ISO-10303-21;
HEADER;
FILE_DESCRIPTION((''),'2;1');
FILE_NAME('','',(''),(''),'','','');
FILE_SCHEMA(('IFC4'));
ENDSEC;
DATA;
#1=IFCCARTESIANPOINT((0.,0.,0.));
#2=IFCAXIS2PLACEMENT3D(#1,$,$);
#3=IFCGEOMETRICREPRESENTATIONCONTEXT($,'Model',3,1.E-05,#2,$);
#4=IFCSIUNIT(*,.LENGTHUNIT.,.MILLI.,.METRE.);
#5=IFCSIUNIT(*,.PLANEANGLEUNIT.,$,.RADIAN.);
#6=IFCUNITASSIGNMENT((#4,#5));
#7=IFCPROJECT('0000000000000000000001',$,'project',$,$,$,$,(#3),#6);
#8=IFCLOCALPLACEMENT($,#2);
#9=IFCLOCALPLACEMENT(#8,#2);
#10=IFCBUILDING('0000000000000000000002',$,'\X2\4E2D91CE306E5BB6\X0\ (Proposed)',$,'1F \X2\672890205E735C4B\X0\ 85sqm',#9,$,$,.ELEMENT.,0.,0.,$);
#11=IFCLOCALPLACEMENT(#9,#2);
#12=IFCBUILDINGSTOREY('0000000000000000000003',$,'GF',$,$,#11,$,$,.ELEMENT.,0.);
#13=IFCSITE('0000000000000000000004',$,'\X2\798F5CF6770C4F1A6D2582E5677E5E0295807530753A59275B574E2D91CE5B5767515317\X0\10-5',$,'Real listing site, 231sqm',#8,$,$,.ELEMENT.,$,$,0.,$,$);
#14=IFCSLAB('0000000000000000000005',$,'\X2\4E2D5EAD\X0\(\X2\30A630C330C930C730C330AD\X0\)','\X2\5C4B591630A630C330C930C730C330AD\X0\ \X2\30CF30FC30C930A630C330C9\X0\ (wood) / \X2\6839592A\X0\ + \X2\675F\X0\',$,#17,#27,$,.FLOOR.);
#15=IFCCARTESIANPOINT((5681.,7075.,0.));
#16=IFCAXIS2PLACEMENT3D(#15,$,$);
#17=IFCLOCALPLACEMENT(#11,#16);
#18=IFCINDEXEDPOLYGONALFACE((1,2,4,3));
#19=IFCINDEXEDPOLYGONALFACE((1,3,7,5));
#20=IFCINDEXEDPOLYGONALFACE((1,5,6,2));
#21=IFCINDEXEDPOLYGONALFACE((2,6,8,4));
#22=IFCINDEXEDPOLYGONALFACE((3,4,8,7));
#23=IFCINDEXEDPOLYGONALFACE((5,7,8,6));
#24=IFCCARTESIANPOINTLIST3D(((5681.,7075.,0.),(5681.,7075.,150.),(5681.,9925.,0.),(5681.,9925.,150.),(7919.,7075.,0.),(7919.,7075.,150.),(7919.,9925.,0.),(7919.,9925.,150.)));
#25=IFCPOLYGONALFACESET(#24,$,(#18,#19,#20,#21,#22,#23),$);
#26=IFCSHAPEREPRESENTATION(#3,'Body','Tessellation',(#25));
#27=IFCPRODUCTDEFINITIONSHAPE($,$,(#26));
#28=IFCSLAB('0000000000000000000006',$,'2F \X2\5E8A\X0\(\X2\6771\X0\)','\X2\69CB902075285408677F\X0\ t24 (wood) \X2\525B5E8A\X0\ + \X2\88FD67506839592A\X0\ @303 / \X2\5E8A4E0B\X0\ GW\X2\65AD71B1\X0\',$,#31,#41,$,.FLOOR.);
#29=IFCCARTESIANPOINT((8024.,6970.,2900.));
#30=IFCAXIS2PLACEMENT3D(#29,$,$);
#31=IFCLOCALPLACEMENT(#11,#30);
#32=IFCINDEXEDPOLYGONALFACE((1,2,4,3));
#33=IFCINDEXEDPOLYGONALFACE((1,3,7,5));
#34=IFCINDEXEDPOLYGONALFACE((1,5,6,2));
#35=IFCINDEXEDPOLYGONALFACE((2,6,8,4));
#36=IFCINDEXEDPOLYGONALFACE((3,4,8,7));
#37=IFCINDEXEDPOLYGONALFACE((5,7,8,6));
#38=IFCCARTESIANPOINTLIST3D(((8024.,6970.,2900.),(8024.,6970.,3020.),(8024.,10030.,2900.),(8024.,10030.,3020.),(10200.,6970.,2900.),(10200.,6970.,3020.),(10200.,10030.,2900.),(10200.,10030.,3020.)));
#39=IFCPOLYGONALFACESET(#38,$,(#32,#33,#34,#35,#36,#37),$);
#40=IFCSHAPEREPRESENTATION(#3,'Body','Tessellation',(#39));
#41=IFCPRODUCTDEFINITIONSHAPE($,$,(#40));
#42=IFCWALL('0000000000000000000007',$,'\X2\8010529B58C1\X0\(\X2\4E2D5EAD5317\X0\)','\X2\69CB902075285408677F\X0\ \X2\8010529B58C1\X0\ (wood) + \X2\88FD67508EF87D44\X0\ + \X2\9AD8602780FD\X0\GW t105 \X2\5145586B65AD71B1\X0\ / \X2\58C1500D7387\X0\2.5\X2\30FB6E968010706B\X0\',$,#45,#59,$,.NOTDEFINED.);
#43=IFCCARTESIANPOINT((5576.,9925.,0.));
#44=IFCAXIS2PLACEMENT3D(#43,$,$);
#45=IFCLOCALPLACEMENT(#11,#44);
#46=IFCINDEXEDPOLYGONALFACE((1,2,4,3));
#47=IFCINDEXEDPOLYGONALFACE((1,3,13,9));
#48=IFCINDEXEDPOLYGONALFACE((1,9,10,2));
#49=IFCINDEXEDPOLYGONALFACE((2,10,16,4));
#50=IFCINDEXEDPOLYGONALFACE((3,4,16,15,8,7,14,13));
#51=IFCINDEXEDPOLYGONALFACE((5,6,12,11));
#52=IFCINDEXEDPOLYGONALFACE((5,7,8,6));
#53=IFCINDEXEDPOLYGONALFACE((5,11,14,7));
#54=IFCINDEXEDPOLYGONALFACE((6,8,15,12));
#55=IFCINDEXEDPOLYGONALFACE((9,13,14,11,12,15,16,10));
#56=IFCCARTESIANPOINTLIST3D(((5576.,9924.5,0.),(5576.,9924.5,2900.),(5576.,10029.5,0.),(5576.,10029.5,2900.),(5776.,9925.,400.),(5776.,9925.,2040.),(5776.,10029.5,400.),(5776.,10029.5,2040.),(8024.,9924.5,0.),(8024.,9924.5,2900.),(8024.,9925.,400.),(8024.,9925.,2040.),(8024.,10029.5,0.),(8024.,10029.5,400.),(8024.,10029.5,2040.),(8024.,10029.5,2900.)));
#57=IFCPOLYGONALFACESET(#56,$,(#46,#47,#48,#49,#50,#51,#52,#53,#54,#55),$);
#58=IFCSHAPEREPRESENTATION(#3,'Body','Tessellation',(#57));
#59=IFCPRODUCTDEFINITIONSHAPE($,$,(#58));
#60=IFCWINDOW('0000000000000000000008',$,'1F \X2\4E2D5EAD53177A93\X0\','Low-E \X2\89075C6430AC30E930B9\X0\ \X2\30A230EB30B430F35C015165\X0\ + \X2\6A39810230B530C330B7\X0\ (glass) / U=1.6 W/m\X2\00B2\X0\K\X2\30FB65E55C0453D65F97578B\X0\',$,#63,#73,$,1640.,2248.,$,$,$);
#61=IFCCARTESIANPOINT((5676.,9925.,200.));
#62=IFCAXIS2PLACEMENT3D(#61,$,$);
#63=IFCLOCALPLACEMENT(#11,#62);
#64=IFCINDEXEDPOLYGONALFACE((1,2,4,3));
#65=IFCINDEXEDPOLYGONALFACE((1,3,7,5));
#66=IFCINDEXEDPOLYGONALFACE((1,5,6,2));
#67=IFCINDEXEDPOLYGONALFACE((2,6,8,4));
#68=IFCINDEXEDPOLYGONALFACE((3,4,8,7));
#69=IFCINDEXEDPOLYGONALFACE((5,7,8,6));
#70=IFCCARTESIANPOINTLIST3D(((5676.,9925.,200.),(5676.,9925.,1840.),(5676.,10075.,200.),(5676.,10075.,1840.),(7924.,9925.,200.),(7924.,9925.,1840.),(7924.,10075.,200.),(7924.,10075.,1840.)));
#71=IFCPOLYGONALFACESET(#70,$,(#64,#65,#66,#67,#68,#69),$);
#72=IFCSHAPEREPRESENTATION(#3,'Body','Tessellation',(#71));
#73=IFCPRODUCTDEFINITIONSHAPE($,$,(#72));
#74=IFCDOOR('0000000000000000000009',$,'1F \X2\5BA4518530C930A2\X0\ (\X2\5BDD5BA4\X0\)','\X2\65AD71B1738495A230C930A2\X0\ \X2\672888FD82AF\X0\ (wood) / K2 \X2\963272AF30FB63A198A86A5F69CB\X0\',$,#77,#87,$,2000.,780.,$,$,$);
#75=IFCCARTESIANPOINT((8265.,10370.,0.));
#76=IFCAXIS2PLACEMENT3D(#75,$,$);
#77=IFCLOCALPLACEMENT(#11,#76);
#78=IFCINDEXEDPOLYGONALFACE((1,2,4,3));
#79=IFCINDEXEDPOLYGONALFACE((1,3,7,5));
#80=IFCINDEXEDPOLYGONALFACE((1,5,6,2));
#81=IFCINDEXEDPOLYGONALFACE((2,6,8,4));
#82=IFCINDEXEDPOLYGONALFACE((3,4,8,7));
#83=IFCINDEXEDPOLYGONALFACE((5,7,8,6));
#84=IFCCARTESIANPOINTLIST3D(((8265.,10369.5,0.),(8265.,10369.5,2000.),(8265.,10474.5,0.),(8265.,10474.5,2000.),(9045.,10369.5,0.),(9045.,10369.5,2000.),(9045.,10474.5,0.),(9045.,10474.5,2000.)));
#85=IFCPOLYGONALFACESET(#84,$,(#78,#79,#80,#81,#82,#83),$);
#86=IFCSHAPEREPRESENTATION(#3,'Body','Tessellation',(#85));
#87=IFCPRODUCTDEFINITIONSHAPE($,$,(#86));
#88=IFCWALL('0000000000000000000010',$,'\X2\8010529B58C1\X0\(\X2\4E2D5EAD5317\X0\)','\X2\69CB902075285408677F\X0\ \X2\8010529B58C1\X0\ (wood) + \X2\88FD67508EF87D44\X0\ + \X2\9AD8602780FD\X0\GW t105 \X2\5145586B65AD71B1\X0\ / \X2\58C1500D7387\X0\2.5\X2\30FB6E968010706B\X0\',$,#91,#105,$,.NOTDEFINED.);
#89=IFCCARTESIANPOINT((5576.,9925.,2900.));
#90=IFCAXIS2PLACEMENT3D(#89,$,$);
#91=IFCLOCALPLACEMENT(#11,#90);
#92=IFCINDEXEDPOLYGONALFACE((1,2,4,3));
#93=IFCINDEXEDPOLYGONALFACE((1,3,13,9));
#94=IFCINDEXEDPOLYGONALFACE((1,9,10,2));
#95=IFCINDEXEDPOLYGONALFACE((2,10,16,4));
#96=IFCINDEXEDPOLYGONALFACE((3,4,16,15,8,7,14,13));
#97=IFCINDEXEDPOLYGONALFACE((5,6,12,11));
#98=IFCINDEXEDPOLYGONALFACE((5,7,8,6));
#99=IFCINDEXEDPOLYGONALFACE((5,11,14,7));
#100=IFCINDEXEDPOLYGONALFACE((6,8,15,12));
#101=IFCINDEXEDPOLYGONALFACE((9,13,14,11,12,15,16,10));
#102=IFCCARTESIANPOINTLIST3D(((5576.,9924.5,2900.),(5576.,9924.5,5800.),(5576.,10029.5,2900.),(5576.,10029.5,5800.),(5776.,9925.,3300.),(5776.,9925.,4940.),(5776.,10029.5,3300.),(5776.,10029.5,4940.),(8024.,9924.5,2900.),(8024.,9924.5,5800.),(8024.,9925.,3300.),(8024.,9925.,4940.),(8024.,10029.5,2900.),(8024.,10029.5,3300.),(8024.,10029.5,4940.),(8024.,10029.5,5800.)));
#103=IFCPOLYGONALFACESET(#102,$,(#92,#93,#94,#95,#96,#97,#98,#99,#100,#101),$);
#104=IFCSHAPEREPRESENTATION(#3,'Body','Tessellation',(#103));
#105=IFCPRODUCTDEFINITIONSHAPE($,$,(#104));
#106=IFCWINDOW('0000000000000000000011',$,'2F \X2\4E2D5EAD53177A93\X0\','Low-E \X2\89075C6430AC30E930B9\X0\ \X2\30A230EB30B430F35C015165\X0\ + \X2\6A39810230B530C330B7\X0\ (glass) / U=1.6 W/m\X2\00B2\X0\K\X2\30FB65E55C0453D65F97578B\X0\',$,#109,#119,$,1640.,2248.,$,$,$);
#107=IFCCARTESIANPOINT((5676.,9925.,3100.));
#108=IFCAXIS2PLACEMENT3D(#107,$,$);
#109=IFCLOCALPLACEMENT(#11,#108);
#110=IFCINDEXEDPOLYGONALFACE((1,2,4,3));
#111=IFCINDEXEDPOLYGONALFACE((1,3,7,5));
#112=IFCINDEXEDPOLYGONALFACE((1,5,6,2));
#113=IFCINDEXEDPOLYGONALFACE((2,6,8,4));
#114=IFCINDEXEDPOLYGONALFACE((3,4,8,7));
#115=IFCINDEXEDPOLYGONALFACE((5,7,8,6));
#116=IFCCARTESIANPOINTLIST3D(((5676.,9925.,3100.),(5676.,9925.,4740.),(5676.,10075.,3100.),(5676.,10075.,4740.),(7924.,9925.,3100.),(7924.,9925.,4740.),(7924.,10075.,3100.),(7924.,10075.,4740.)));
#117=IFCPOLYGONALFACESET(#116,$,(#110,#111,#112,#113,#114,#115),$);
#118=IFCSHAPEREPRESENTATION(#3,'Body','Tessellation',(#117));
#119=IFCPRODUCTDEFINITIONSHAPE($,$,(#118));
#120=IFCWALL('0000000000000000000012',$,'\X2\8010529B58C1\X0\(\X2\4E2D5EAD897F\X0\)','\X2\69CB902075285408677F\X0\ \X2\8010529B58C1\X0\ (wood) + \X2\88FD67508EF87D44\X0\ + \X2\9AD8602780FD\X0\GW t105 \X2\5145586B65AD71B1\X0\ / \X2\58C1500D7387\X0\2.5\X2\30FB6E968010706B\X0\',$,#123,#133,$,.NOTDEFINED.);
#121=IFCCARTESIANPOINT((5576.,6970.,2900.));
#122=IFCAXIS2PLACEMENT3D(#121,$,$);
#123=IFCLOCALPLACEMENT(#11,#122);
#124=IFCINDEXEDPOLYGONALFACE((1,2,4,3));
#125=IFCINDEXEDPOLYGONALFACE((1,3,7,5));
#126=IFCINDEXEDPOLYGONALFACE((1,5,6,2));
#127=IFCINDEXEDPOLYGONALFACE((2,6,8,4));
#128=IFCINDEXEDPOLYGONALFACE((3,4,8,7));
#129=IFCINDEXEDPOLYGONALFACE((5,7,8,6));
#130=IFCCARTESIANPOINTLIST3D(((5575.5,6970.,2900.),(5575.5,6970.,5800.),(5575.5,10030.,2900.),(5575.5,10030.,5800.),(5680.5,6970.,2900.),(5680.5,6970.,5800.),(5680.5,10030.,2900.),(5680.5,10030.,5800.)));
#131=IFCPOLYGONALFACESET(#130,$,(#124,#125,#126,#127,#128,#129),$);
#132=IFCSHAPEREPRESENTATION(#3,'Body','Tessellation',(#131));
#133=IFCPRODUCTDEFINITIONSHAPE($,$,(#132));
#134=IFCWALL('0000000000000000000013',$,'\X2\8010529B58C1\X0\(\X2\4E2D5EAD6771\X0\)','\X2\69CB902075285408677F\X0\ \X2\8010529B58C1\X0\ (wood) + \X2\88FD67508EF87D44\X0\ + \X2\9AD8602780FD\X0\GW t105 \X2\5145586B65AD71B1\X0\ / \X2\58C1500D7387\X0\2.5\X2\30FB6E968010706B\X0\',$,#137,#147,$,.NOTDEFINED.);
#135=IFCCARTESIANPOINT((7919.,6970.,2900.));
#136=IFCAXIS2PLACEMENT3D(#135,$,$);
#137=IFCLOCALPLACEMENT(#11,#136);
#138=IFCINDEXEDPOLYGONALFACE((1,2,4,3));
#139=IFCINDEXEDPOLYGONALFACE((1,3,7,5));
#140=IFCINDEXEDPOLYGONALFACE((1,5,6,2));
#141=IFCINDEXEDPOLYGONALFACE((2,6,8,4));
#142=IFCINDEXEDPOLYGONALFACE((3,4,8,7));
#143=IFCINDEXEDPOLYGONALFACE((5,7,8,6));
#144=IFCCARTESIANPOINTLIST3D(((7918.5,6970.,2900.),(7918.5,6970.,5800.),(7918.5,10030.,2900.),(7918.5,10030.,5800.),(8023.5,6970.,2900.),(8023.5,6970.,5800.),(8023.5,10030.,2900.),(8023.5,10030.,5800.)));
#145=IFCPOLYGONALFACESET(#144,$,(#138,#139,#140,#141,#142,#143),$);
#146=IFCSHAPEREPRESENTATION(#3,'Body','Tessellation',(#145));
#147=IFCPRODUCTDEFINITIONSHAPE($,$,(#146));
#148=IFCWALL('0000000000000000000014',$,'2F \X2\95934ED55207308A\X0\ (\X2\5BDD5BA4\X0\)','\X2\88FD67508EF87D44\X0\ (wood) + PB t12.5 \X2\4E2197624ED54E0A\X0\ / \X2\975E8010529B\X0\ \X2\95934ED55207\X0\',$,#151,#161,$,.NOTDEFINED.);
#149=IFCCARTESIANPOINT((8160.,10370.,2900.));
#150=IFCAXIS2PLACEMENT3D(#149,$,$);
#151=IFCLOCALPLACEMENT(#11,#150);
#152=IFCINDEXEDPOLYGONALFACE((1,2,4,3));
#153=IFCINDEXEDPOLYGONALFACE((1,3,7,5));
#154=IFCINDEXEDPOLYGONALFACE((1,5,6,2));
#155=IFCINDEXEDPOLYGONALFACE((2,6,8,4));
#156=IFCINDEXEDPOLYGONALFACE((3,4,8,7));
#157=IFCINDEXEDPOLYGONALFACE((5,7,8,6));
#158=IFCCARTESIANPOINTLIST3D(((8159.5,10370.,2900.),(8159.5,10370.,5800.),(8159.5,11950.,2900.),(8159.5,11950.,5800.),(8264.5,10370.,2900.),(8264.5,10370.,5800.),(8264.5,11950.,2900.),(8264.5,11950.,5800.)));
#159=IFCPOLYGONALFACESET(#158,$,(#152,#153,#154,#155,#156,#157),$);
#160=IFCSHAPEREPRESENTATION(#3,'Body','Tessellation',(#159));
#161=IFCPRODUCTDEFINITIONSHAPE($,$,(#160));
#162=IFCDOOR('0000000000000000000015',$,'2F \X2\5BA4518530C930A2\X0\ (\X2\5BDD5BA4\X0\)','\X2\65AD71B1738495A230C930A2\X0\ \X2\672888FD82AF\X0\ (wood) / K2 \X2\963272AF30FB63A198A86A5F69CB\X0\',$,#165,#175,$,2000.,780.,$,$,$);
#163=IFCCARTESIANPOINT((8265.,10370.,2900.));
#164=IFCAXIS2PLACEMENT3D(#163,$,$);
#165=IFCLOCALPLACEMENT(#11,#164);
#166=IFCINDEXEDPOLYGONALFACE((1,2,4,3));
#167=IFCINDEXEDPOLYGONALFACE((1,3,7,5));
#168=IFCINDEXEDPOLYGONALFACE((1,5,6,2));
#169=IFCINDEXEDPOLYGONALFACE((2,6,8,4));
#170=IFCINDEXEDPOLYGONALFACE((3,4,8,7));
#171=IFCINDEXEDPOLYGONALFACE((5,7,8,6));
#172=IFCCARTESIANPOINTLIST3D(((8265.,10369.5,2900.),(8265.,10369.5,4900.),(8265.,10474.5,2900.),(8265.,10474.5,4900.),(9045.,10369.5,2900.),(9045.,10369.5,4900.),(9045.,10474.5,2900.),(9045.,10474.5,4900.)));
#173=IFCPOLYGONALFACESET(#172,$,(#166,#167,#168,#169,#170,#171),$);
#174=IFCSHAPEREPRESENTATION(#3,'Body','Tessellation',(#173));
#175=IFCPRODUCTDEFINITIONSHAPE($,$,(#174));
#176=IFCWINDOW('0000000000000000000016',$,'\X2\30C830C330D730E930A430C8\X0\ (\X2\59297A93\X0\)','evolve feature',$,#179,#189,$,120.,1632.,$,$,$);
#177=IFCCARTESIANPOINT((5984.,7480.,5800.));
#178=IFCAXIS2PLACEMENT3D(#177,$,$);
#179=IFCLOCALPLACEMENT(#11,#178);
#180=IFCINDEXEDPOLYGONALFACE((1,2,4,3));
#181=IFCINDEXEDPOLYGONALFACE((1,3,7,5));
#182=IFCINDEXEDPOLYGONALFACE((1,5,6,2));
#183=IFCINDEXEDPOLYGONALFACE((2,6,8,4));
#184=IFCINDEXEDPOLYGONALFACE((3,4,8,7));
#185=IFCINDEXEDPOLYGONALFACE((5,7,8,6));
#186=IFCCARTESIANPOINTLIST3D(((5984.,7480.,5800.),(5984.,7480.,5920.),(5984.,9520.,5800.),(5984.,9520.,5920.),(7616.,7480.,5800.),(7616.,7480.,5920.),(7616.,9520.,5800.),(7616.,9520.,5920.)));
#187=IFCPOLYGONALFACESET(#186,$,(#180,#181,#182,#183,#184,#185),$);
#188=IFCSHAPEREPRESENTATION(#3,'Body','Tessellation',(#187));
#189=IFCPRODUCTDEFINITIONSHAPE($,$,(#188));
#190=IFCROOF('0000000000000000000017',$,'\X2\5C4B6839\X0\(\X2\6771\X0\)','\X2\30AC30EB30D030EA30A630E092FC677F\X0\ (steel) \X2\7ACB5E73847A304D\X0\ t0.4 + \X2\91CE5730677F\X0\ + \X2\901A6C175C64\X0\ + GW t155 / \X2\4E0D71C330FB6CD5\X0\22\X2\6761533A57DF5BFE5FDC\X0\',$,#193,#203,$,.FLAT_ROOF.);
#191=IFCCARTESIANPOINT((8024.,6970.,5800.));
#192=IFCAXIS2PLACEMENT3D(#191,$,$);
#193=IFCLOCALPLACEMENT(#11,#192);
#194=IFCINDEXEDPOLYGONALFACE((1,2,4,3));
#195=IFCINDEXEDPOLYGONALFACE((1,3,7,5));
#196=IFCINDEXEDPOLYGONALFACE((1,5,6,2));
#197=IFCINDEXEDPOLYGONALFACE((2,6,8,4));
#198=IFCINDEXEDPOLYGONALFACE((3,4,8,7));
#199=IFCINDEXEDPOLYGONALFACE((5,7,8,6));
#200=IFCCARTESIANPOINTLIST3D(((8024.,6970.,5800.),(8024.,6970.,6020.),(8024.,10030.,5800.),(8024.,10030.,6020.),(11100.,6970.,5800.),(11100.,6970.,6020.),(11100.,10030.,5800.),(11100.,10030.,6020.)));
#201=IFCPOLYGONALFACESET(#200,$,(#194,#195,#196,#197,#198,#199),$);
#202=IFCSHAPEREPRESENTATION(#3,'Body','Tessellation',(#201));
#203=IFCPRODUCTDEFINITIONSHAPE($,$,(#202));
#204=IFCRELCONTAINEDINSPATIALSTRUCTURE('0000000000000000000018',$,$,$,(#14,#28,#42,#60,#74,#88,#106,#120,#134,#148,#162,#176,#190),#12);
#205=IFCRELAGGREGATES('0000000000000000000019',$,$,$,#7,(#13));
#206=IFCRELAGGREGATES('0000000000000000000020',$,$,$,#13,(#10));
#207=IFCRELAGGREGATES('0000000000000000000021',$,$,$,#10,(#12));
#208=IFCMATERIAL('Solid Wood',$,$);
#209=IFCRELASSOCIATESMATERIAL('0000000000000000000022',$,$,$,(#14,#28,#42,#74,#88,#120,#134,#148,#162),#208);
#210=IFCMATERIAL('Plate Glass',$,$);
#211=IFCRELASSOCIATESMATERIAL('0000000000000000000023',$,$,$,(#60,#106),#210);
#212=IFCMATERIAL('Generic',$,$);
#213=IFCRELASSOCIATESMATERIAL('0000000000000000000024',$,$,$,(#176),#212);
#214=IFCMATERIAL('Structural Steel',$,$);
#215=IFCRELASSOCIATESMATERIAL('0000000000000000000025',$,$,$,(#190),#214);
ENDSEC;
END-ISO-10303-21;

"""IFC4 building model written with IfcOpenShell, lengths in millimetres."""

from ifc_helpers import new_model, si_unit, frame, frame_2d, origin, place, context, project, spatial, rectangle, extrude, material, element, fill, save


model = new_model("IFC4")

# Units and contexts
model_context = context("Model", 3, precision=1e-05, world=origin())
ifc_project = project(units=[si_unit("LENGTHUNIT", "METRE", prefix="MILLI"), si_unit("PLANEANGLEUNIT", "RADIAN")], contexts=[model_context])

# Site, building, storey
site_placement = place(None, origin())
site = spatial("IfcSite", under=ifc_project, at=site_placement, Name="福島県会津若松市門田町大字中野字村北10-5", ObjectType="Real listing site, 231sqm", CompositionType="ELEMENT", RefElevation=0.0)
building_placement = place(site_placement, origin())
building = spatial("IfcBuilding", under=site, at=building_placement, Name="中野の家 (Proposed)", ObjectType="1F 木造平屋 85sqm", CompositionType="ELEMENT", ElevationOfRefHeight=0.0, ElevationOfTerrain=0.0)
storey_placement = place(building_placement, origin())
storey = spatial("IfcBuildingStorey", under=building, at=storey_placement, Name="GF", CompositionType="ELEMENT", Elevation=0.0)

# Slabs
ifc_material_1 = material(Name="Solid Wood")
slab_1_placement = place(storey_placement, frame((5681.0, 7075.0, 0.0)))
element("IfcSlab", 1, at=slab_1_placement, inside=storey, material=ifc_material_1, Name="中庭(ウッドデッキ)", Description="屋外ウッドデッキ ハードウッド (wood) / 根太 + 束", PredefinedType="FLOOR", context=model_context, shape_type="SweptSolid", body=[
    extrude(rectangle(XDim=2238.0, YDim=2850.0, at=frame_2d((1119.0, 1425.0))), frame((5681.0, 7075.0, 0.0)), (0.0, 0.0, 1.0), 150.0),
])
slab_2_placement = place(storey_placement, frame((8024.0, 6970.0, 2900.0)))
element("IfcSlab", 2, at=slab_2_placement, inside=storey, material=ifc_material_1, Name="2F 床(東)", Description="構造用合板 t24 (wood) 剛床 + 製材根太 @303 / 床下 GW断熱", PredefinedType="FLOOR", context=model_context, shape_type="SweptSolid", body=[
    extrude(rectangle(XDim=2176.0, YDim=3060.0, at=frame_2d((1088.0, 1530.0))), frame((8024.0, 6970.0, 2900.0)), (0.0, 0.0, 1.0), 120.0),
])

# Wall, opening, window
wall_1_placement = place(storey_placement, frame((5576.0, 9925.0, 0.0)))
wall_1 = element("IfcWall", 3, at=wall_1_placement, inside=storey, material=ifc_material_1, Name="耐力壁(中庭北)", Description="構造用合板 耐力壁 (wood) + 製材軸組 + 高性能GW t105 充填断熱 / 壁倍率2.5・準耐火", PredefinedType="NOTDEFINED", context=model_context, shape_type="SweptSolid", body=[
    extrude(rectangle(XDim=2448.0, YDim=105.0, at=frame_2d((1224.0, 52.0))), frame((5576.0, 9925.0, 0.0)), (0.0, 0.0, 1.0), 2900.0),
])
opening_1_placement = place(storey_placement, frame((5676.0, 9925.0, 200.0)))
opening_1 = element("IfcOpeningElement", 4, at=opening_1_placement, cuts=wall_1, PredefinedType="NOTDEFINED", context=model_context, shape_type="SweptSolid", body=[
    extrude(rectangle(XDim=2248.0, YDim=150.0, at=frame_2d((1124.0, 75.0))), frame((5676.0, 9925.0, 200.0)), (0.0, 0.0, 1.0), 1640.0),
])
ifc_material_2 = material(Name="Plate Glass")
window_1_placement = place(storey_placement, frame((5676.0, 9925.0, 200.0)))
window_1 = element("IfcWindow", 5, at=window_1_placement, inside=storey, material=ifc_material_2, Name="1F 中庭北窓", Description="Low-E 複層ガラス アルゴン封入 + 樹脂サッシ (glass) / U=1.6 W/m²K・日射取得型", OverallHeight=1640.0, OverallWidth=2248.0, context=model_context, shape_type="SweptSolid", body=[
    extrude(rectangle(XDim=2248.0, YDim=150.0, at=frame_2d((1124.0, 75.0))), frame((5676.0, 9925.0, 200.0)), (0.0, 0.0, 1.0), 1640.0),
])
fill(opening_1, window_1)

# Door
door_1_placement = place(storey_placement, frame((8265.0, 10370.0, 0.0)))
element("IfcDoor", 6, at=door_1_placement, inside=storey, material=ifc_material_1, Name="1F 室内ドア (寝室)", Description="断熱玄関ドア 木製芯 (wood) / K2 防犯・採風機構", OverallHeight=2000.0, OverallWidth=780.0, context=model_context, shape_type="SweptSolid", body=[
    extrude(rectangle(XDim=780.0, YDim=105.0, at=frame_2d((390.0, 52.0))), frame((8265.0, 10370.0, 0.0)), (0.0, 0.0, 1.0), 2000.0),
])

# Wall, opening, window
wall_2_placement = place(storey_placement, frame((5576.0, 9925.0, 2900.0)))
wall_2 = element("IfcWall", 7, at=wall_2_placement, inside=storey, material=ifc_material_1, Name="耐力壁(中庭北)", Description="構造用合板 耐力壁 (wood) + 製材軸組 + 高性能GW t105 充填断熱 / 壁倍率2.5・準耐火", PredefinedType="NOTDEFINED", context=model_context, shape_type="SweptSolid", body=[
    extrude(rectangle(XDim=2448.0, YDim=105.0, at=frame_2d((1224.0, 52.0))), frame((5576.0, 9925.0, 2900.0)), (0.0, 0.0, 1.0), 2900.0),
])
opening_2_placement = place(storey_placement, frame((5676.0, 9925.0, 3100.0)))
opening_2 = element("IfcOpeningElement", 8, at=opening_2_placement, cuts=wall_2, PredefinedType="NOTDEFINED", context=model_context, shape_type="SweptSolid", body=[
    extrude(rectangle(XDim=2248.0, YDim=150.0, at=frame_2d((1124.0, 75.0))), frame((5676.0, 9925.0, 3100.0)), (0.0, 0.0, 1.0), 1640.0),
])
window_2_placement = place(storey_placement, frame((5676.0, 9925.0, 3100.0)))
window_2 = element("IfcWindow", 9, at=window_2_placement, inside=storey, material=ifc_material_2, Name="2F 中庭北窓", Description="Low-E 複層ガラス アルゴン封入 + 樹脂サッシ (glass) / U=1.6 W/m²K・日射取得型", OverallHeight=1640.0, OverallWidth=2248.0, context=model_context, shape_type="SweptSolid", body=[
    extrude(rectangle(XDim=2248.0, YDim=150.0, at=frame_2d((1124.0, 75.0))), frame((5676.0, 9925.0, 3100.0)), (0.0, 0.0, 1.0), 1640.0),
])
fill(opening_2, window_2)

# Walls
wall_3_placement = place(storey_placement, frame((5576.0, 6970.0, 2900.0)))
element("IfcWall", 10, at=wall_3_placement, inside=storey, material=ifc_material_1, Name="耐力壁(中庭西)", Description="構造用合板 耐力壁 (wood) + 製材軸組 + 高性能GW t105 充填断熱 / 壁倍率2.5・準耐火", PredefinedType="NOTDEFINED", context=model_context, shape_type="SweptSolid", body=[
    extrude(rectangle(XDim=105.0, YDim=3060.0, at=frame_2d((52.0, 1530.0))), frame((5576.0, 6970.0, 2900.0)), (0.0, 0.0, 1.0), 2900.0),
])
wall_4_placement = place(storey_placement, frame((7919.0, 6970.0, 2900.0)))
element("IfcWall", 11, at=wall_4_placement, inside=storey, material=ifc_material_1, Name="耐力壁(中庭東)", Description="構造用合板 耐力壁 (wood) + 製材軸組 + 高性能GW t105 充填断熱 / 壁倍率2.5・準耐火", PredefinedType="NOTDEFINED", context=model_context, shape_type="SweptSolid", body=[
    extrude(rectangle(XDim=105.0, YDim=3060.0, at=frame_2d((52.0, 1530.0))), frame((7919.0, 6970.0, 2900.0)), (0.0, 0.0, 1.0), 2900.0),
])
wall_5_placement = place(storey_placement, frame((8160.0, 10370.0, 2900.0)))
element("IfcWall", 12, at=wall_5_placement, inside=storey, material=ifc_material_1, Name="2F 間仕切り (寝室)", Description="製材軸組 (wood) + PB t12.5 両面仕上 / 非耐力 間仕切", PredefinedType="NOTDEFINED", context=model_context, shape_type="SweptSolid", body=[
    extrude(rectangle(XDim=105.0, YDim=1580.0, at=frame_2d((52.0, 790.0))), frame((8160.0, 10370.0, 2900.0)), (0.0, 0.0, 1.0), 2900.0),
])

# Door
door_2_placement = place(storey_placement, frame((8265.0, 10370.0, 2900.0)))
element("IfcDoor", 13, at=door_2_placement, inside=storey, material=ifc_material_1, Name="2F 室内ドア (寝室)", Description="断熱玄関ドア 木製芯 (wood) / K2 防犯・採風機構", OverallHeight=2000.0, OverallWidth=780.0, context=model_context, shape_type="SweptSolid", body=[
    extrude(rectangle(XDim=780.0, YDim=105.0, at=frame_2d((390.0, 52.0))), frame((8265.0, 10370.0, 2900.0)), (0.0, 0.0, 1.0), 2000.0),
])

# Window
ifc_material_3 = material(Name="Generic")
window_3_placement = place(storey_placement, frame((5984.0, 7480.0, 5800.0)))
element("IfcWindow", 14, at=window_3_placement, inside=storey, material=ifc_material_3, Name="トップライト (天窓)", Description="evolve feature", OverallHeight=120.0, OverallWidth=1632.0, context=model_context, shape_type="SweptSolid", body=[
    extrude(rectangle(XDim=1632.0, YDim=2040.0, at=frame_2d((816.0, 1020.0))), frame((5984.0, 7480.0, 5800.0)), (0.0, 0.0, 1.0), 120.0),
])

# Roof
ifc_material_4 = material(Name="Structural Steel")
roof_placement = place(storey_placement, frame((8024.0, 6970.0, 5800.0)))
element("IfcRoof", 15, at=roof_placement, inside=storey, material=ifc_material_4, Name="屋根(東)", Description="ガルバリウム鋼板 (steel) 立平葺き t0.4 + 野地板 + 通気層 + GW t155 / 不燃・法22条区域対応", PredefinedType="FLAT_ROOF", context=model_context, shape_type="SweptSolid", body=[
    extrude(rectangle(XDim=3076.0, YDim=3060.0, at=frame_2d((1538.0, 1530.0))), frame((8024.0, 6970.0, 5800.0)), (0.0, 0.0, 1.0), 220.0),
])

save(model, "model.ifc")
